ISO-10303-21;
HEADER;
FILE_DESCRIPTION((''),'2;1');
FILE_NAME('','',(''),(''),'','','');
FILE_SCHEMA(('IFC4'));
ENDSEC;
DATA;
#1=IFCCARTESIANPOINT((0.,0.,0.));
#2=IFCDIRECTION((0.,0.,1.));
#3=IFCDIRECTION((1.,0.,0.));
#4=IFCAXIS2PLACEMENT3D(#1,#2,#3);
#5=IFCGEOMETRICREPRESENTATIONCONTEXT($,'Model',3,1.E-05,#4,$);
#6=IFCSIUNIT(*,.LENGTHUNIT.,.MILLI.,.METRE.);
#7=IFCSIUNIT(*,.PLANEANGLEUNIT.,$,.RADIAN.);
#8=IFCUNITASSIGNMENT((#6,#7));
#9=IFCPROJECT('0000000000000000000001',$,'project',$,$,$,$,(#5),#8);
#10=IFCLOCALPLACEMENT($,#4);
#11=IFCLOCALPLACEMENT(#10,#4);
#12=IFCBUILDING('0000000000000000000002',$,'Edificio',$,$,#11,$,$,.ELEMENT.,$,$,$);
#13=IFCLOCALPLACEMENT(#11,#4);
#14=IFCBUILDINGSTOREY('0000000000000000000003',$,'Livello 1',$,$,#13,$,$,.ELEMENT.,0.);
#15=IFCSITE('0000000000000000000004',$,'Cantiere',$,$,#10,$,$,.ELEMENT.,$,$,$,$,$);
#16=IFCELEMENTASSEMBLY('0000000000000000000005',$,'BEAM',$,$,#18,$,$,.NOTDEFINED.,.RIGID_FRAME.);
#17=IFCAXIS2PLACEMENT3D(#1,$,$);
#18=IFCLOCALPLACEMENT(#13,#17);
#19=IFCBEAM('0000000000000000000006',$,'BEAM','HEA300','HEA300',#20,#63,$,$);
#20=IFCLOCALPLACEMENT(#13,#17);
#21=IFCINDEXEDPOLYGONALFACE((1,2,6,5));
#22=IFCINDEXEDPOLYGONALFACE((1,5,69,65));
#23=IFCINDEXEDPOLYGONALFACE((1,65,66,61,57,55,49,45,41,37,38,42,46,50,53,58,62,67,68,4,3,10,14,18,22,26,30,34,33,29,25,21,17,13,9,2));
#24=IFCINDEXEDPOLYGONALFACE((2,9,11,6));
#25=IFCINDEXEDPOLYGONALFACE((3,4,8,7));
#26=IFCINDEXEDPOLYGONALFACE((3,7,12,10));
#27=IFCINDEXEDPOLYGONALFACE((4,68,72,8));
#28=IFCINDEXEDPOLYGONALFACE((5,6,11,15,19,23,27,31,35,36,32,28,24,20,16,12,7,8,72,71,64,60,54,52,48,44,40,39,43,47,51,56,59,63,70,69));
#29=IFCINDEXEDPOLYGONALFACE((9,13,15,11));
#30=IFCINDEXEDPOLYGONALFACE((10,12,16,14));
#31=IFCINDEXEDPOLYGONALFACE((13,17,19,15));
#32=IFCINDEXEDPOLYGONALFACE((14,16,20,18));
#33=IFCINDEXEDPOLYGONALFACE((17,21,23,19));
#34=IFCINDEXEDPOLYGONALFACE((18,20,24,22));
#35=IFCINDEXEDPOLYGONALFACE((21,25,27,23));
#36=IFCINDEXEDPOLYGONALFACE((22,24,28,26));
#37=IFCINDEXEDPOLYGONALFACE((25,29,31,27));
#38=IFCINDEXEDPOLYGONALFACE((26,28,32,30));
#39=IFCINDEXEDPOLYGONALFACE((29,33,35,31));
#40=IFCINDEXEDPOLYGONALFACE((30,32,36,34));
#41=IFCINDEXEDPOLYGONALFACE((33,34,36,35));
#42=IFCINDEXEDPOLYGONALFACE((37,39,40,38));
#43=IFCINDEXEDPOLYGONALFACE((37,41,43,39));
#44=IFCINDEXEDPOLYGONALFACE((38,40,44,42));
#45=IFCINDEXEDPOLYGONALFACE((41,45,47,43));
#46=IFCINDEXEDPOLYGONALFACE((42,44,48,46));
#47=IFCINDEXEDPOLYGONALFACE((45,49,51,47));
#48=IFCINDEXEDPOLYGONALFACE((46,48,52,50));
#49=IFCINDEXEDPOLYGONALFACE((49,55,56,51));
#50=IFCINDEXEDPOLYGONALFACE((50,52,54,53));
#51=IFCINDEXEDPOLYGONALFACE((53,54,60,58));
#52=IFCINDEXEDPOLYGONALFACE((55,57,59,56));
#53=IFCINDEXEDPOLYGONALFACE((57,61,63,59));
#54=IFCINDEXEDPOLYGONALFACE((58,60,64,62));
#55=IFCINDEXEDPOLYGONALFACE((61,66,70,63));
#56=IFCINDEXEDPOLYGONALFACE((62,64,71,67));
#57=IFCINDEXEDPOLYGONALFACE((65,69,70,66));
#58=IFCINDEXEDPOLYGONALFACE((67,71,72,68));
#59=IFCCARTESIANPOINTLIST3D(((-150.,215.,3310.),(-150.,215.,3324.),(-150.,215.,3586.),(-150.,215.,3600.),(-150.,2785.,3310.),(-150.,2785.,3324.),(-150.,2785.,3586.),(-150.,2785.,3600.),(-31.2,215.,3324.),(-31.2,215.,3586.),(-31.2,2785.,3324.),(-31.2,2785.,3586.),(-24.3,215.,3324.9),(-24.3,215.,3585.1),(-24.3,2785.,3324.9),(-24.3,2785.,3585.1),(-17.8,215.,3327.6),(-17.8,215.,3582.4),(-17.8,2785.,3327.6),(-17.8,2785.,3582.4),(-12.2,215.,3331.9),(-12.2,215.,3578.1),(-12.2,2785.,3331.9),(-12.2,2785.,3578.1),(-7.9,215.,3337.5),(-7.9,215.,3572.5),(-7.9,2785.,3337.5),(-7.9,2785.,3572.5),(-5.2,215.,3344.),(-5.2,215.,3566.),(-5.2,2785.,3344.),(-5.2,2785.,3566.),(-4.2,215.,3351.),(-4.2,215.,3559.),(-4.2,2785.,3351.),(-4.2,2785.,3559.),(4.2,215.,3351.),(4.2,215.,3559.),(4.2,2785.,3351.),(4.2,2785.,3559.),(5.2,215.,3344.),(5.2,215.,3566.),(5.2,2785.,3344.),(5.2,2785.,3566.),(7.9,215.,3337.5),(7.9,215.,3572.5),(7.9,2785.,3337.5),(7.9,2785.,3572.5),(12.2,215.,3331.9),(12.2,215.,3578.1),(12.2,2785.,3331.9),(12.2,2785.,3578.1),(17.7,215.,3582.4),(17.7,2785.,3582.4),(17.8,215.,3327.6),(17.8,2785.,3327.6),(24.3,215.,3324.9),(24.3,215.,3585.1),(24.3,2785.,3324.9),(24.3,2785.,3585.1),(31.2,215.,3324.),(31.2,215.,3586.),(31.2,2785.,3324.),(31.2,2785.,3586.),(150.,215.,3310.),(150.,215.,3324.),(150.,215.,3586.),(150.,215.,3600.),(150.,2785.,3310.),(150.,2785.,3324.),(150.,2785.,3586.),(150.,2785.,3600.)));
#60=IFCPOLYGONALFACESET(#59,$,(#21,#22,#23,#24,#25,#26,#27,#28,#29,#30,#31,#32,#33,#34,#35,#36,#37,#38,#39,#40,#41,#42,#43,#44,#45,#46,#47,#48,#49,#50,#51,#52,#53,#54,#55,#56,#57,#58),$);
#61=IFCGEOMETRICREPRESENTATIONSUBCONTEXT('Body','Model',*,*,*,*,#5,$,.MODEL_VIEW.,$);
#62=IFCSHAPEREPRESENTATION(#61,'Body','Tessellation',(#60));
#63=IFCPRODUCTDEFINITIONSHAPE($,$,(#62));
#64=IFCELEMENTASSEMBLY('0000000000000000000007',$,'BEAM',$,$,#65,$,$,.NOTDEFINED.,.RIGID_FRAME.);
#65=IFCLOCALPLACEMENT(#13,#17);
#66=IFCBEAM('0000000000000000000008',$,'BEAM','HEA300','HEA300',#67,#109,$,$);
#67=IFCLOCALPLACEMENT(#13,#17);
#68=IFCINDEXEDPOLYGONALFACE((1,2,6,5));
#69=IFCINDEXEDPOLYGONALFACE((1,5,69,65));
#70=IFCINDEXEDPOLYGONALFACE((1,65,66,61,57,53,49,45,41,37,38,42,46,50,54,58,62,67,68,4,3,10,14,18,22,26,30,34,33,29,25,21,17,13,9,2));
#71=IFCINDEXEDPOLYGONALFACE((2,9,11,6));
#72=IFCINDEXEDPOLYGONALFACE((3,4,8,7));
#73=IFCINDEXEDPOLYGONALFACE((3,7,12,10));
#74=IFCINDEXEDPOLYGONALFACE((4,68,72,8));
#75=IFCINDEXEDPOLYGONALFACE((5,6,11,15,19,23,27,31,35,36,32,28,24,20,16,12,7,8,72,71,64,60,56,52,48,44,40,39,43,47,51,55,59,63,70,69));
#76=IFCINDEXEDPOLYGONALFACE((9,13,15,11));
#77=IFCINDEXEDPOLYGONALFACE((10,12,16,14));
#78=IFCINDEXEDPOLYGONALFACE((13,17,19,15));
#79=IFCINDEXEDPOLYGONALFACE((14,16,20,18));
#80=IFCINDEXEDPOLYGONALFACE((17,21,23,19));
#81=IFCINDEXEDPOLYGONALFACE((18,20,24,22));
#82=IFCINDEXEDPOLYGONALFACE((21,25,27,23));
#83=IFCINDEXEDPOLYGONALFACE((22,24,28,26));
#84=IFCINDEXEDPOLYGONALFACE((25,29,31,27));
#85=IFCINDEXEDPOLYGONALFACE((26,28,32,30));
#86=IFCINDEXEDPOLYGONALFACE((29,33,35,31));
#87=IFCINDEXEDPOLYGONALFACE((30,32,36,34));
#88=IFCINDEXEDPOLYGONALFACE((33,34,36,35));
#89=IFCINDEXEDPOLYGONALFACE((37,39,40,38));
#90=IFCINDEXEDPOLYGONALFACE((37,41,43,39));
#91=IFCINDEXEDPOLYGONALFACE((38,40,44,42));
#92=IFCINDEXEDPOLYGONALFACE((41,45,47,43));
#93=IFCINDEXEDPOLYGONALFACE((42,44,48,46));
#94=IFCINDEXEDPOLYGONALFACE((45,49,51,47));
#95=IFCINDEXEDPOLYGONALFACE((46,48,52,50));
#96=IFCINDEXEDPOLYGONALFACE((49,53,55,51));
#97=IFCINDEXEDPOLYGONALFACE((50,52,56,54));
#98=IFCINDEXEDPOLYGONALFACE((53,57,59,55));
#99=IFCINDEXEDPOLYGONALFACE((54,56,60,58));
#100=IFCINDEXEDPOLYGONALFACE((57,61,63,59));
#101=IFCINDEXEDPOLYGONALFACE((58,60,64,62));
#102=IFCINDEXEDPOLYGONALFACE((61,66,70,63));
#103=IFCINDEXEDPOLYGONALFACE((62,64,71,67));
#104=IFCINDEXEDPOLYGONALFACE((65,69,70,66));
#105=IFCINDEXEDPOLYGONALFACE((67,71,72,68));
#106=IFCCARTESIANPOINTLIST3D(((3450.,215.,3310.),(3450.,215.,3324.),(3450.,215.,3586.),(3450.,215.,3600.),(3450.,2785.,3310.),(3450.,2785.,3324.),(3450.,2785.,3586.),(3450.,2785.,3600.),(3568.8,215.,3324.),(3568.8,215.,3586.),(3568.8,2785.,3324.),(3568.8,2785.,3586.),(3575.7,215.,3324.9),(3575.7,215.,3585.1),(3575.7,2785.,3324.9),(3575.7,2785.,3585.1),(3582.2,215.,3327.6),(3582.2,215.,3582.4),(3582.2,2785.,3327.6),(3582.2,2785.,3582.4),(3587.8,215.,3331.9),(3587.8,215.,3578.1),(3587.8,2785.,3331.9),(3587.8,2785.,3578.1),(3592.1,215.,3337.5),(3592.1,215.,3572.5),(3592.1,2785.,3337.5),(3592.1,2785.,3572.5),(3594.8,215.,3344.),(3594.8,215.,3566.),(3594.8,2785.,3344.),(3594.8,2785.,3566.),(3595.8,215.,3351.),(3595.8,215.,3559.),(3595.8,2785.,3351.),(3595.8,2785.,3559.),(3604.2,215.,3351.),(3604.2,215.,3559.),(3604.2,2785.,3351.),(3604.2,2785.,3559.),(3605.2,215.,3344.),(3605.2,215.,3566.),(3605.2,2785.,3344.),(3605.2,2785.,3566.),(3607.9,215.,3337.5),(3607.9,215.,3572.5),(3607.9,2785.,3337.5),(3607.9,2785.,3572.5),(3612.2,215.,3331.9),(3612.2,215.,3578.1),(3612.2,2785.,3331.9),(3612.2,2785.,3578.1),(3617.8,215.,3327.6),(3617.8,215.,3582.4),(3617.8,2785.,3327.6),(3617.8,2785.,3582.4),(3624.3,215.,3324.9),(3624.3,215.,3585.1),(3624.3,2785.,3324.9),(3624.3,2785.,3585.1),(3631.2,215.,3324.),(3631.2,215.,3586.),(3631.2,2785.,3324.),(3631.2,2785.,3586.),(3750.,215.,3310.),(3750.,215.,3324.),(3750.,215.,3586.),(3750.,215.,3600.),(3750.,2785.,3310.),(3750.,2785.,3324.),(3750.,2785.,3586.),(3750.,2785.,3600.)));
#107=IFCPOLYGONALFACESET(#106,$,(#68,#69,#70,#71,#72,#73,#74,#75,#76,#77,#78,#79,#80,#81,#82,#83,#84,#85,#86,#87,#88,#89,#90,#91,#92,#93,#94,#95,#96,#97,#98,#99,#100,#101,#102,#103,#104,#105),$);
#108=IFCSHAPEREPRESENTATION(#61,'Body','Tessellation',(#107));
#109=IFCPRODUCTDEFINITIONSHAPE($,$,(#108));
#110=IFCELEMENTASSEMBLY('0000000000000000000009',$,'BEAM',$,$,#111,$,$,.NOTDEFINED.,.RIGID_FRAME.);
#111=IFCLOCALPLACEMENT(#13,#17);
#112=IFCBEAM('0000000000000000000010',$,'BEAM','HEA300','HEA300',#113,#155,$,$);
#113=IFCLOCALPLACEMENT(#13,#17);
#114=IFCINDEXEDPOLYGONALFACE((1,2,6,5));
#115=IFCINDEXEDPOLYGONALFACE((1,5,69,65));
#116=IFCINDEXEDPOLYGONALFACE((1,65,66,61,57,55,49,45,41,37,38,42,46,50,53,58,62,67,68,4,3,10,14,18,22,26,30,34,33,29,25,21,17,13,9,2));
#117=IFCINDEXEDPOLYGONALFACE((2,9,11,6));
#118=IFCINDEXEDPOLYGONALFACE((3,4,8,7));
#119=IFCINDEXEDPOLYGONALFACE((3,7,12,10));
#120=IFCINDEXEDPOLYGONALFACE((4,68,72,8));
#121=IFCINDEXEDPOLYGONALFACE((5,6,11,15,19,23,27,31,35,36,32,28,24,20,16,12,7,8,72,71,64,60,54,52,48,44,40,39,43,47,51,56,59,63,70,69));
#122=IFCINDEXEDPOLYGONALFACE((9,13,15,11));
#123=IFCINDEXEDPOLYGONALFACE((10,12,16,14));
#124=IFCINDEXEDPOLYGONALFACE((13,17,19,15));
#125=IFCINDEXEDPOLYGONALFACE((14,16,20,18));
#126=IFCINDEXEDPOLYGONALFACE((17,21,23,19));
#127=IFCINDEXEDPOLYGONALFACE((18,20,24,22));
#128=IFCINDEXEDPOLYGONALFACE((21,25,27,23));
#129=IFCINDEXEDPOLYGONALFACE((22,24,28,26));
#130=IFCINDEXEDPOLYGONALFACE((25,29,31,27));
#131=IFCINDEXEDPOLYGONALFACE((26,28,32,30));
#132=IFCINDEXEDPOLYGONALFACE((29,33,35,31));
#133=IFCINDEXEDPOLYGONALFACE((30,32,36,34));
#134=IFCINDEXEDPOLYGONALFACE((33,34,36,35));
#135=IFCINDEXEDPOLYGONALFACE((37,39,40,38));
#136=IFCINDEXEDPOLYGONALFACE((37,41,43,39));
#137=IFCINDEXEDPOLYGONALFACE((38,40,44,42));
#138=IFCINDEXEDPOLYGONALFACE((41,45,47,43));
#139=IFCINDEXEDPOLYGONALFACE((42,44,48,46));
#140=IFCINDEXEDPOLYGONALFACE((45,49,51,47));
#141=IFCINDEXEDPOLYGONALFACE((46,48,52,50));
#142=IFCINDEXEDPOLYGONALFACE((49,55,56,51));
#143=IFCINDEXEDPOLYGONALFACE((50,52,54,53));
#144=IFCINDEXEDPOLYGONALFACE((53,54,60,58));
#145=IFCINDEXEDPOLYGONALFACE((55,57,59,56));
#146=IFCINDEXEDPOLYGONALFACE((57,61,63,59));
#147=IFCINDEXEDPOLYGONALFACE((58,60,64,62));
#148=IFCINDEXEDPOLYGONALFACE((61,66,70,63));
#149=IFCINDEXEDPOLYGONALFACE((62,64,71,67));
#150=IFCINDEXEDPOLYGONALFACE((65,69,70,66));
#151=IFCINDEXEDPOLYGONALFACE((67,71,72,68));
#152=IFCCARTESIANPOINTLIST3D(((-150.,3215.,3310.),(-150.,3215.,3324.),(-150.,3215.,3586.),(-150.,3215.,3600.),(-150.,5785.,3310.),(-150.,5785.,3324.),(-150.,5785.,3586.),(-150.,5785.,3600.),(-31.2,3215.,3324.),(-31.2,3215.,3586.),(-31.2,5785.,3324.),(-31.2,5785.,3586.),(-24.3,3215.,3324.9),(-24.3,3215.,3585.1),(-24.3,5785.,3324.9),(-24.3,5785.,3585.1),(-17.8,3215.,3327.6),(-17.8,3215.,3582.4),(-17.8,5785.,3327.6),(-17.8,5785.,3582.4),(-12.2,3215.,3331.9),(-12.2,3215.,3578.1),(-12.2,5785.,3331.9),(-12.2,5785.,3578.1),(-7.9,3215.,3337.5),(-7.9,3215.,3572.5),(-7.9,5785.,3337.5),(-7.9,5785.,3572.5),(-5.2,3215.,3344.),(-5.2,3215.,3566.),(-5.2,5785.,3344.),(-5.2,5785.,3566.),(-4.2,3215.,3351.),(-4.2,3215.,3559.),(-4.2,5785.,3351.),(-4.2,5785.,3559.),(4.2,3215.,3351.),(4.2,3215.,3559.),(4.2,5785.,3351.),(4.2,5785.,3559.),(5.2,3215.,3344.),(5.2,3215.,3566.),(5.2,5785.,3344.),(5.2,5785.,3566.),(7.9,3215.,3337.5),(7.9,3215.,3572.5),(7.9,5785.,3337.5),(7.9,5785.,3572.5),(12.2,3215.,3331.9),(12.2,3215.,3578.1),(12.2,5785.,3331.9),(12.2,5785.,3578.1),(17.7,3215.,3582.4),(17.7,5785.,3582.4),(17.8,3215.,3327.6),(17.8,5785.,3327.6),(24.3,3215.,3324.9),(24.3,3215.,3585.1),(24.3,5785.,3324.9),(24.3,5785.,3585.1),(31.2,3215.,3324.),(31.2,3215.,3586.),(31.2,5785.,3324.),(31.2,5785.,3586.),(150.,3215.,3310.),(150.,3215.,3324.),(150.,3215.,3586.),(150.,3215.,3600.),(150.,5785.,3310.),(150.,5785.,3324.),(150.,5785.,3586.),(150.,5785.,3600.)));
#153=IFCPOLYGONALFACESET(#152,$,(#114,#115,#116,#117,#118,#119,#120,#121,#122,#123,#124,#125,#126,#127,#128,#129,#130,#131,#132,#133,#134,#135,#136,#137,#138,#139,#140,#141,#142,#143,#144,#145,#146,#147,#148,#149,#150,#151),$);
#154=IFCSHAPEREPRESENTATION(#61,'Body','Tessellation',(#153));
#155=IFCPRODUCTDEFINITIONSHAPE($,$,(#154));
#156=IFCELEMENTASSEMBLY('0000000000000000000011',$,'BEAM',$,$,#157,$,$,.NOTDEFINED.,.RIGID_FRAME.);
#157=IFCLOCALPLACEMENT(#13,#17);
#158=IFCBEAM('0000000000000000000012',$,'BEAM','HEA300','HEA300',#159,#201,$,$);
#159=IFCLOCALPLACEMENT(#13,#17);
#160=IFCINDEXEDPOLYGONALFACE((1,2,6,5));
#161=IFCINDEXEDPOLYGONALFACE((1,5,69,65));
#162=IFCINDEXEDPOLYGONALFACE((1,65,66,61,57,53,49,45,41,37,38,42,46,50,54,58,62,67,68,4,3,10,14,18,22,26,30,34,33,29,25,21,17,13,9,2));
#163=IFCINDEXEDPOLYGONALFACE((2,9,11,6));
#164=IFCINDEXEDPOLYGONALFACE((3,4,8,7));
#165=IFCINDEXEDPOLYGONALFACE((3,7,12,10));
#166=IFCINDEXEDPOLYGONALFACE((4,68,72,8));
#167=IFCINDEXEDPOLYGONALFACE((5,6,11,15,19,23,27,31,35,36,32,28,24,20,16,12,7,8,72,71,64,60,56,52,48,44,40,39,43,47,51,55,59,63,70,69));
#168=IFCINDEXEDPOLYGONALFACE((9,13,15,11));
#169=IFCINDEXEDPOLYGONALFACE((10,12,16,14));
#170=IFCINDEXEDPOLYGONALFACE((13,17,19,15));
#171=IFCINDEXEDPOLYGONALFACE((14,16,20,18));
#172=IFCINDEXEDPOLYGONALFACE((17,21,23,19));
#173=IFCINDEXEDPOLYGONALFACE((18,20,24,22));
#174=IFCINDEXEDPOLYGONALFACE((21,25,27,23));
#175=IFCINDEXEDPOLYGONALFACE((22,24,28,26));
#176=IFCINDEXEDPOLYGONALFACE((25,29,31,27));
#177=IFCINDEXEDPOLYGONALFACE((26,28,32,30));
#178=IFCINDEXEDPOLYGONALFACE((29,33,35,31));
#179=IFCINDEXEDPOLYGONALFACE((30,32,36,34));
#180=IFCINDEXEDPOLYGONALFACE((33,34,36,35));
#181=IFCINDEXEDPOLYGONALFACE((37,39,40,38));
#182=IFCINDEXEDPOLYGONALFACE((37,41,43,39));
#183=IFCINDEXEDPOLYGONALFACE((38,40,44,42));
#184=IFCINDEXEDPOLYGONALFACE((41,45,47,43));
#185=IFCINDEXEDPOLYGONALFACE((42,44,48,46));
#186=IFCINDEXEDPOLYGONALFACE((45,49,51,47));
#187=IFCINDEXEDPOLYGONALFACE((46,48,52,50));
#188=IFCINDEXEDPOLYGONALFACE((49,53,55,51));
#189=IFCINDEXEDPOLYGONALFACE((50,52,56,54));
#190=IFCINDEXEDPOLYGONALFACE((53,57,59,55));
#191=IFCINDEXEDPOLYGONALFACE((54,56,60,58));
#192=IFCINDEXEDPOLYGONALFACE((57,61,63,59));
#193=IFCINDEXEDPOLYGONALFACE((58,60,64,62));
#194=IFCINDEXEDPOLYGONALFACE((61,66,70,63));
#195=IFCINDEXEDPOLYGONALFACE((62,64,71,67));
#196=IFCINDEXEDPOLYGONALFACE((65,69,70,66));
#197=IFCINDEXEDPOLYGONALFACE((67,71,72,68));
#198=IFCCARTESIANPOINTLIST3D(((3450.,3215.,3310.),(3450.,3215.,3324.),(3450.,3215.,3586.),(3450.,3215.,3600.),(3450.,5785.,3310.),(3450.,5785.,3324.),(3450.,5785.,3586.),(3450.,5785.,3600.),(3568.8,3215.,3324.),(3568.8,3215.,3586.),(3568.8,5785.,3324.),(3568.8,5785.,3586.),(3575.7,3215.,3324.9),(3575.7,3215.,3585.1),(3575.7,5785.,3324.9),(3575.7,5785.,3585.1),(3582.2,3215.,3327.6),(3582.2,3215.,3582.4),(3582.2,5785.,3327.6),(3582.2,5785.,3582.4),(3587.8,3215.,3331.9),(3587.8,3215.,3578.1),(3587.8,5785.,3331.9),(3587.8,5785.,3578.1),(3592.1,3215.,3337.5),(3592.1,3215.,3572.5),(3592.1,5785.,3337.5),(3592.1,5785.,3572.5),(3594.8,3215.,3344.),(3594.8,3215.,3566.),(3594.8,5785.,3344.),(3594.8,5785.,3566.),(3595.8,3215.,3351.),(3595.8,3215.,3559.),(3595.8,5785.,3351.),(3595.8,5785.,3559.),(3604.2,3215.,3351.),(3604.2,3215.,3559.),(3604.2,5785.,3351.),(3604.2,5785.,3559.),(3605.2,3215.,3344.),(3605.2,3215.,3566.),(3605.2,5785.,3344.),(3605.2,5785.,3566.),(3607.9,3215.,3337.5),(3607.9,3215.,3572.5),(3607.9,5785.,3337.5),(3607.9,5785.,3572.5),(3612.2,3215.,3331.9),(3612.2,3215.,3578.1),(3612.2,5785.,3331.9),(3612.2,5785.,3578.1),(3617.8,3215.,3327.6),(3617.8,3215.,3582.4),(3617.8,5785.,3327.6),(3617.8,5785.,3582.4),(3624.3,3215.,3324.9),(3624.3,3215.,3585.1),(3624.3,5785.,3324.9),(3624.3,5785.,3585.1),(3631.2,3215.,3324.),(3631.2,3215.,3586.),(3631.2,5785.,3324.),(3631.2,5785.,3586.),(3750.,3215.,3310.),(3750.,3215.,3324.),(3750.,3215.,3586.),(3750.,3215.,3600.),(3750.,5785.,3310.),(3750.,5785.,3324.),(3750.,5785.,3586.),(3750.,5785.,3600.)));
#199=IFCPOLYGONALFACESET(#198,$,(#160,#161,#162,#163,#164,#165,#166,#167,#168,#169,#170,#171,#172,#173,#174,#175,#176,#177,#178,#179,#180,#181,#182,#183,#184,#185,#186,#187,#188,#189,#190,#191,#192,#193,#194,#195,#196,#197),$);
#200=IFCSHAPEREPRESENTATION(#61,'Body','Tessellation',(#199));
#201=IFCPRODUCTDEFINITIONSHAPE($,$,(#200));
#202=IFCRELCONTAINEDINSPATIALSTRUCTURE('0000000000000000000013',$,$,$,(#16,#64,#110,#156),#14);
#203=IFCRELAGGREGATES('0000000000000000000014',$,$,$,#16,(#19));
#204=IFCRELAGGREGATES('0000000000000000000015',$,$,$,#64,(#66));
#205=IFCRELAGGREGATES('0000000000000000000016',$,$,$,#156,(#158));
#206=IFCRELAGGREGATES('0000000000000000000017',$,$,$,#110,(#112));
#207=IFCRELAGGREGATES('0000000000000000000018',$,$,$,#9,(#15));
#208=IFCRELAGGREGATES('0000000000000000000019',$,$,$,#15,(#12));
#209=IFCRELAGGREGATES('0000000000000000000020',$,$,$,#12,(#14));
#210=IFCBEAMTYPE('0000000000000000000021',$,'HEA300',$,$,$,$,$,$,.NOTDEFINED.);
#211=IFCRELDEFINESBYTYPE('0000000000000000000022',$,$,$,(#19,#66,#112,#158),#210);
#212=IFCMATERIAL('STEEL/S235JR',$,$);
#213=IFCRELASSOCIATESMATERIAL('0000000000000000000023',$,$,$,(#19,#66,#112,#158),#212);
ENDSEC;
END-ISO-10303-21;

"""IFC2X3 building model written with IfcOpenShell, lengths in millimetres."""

from ifc_helpers import new_model, si_unit, frame, origin_with_axes, origin_2d_with_axis, place, context, subcontext, project, spatial, i_section, extrude, clip, halfspace, material, type_object, element, aggregate, save


model = new_model("IFC2X3")

# Units and contexts
model_context = context("Model", 3, precision=1e-05, world=origin_with_axes())
body_context = subcontext(model_context, "Body", "Model", "MODEL_VIEW")
ifc_project = project(units=[si_unit("LENGTHUNIT", "METRE", prefix="MILLI"), si_unit("PLANEANGLEUNIT", "RADIAN")], contexts=[model_context])

# Site, building, storey
site_placement = place(None, origin_with_axes())
site = spatial("IfcSite", under=ifc_project, at=site_placement, Name="Cantiere", CompositionType="ELEMENT")
building_placement = place(site_placement, origin_with_axes())
building = spatial("IfcBuilding", under=site, at=building_placement, Name="Edificio", CompositionType="ELEMENT")
storey_placement = place(building_placement, origin_with_axes())
storey = spatial("IfcBuildingStorey", under=building, at=storey_placement, Name="Livello 1", CompositionType="ELEMENT", Elevation=0.0)

# Element assemblies, beams
assembly_1_placement = place(storey_placement, origin_with_axes())
assembly_1 = element("IfcElementAssembly", 1, at=assembly_1_placement, inside=storey, Name="BEAM", AssemblyPlace="NOTDEFINED", PredefinedType="RIGID_FRAME")
ifc_material_1 = material(Name="STEEL/S235JR")
beam_type = type_object("IfcBeamType", Name="HEA300", PredefinedType="NOTDEFINED")
beam_1_placement = place(assembly_1_placement, frame((0.0, 3000.0, 3455.0), z_axis=(0.0, 0.0, 1.0), x_axis=(0.0, -1.0, 0.0)))
beam_1 = element("IfcBeam", 2, at=beam_1_placement, type_object=beam_type, material=ifc_material_1, Name="BEAM", Description="HEA300", ObjectType="HEA300", context=body_context, shape_type="Clipping", body=[
    clip(clip(extrude(i_section(OverallWidth=300.0, OverallDepth=290.0, WebThickness=8.5, FlangeThickness=14.0, FilletRadius=27.0, at=origin_2d_with_axis()), frame((2785.0, 0.0, 0.0), z_axis=(-1.0, 0.0, 0.0), x_axis=(0.0, -1.0, 0.0)), (0.0, 0.0, 1.0), 2570.0), halfspace(frame((2785.0, 0.0, -145.0), z_axis=(-1.0, 0.0, 0.0), x_axis=(0.0, 1.0, 0.0)), True)), halfspace(frame((215.0, 0.0, -145.0), z_axis=(1.0, 0.0, 0.0), x_axis=(0.0, -1.0, 0.0)), True)),
])
aggregate(assembly_1, [beam_1])
assembly_2_placement = place(storey_placement, origin_with_axes())
assembly_2 = element("IfcElementAssembly", 3, at=assembly_2_placement, inside=storey, Name="BEAM", AssemblyPlace="NOTDEFINED", PredefinedType="RIGID_FRAME")
beam_2_placement = place(assembly_2_placement, frame((3600.0, 3000.0, 3455.0), z_axis=(0.0, 0.0, 1.0), x_axis=(0.0, -1.0, 0.0)))
beam_2 = element("IfcBeam", 4, at=beam_2_placement, type_object=beam_type, material=ifc_material_1, Name="BEAM", Description="HEA300", ObjectType="HEA300", context=body_context, shape_type="Clipping", body=[
    clip(clip(extrude(i_section(OverallWidth=300.0, OverallDepth=290.0, WebThickness=8.5, FlangeThickness=14.0, FilletRadius=27.0, at=origin_2d_with_axis()), frame((2785.0, 0.0, 0.0), z_axis=(-1.0, 0.0, 0.0), x_axis=(0.0, -1.0, 0.0)), (0.0, 0.0, 1.0), 2570.0), halfspace(frame((2785.0, 0.0, -145.0), z_axis=(-1.0, 0.0, 0.0), x_axis=(0.0, 1.0, 0.0)), True)), halfspace(frame((215.0, 0.0, -145.0), z_axis=(1.0, 0.0, 0.0), x_axis=(0.0, -1.0, 0.0)), True)),
])
aggregate(assembly_2, [beam_2])
assembly_3_placement = place(storey_placement, origin_with_axes())
assembly_3 = element("IfcElementAssembly", 5, at=assembly_3_placement, inside=storey, Name="BEAM", AssemblyPlace="NOTDEFINED", PredefinedType="RIGID_FRAME")
beam_3_placement = place(assembly_3_placement, frame((0.0, 6000.0, 3455.0), z_axis=(0.0, 0.0, 1.0), x_axis=(0.0, -1.0, 0.0)))
beam_3 = element("IfcBeam", 6, at=beam_3_placement, type_object=beam_type, material=ifc_material_1, Name="BEAM", Description="HEA300", ObjectType="HEA300", context=body_context, shape_type="Clipping", body=[
    clip(clip(extrude(i_section(OverallWidth=300.0, OverallDepth=290.0, WebThickness=8.5, FlangeThickness=14.0, FilletRadius=27.0, at=origin_2d_with_axis()), frame((2785.0, 0.0, 0.0), z_axis=(-1.0, 0.0, 0.0), x_axis=(0.0, -1.0, 0.0)), (0.0, 0.0, 1.0), 2570.0), halfspace(frame((2785.0, 0.0, -145.0), z_axis=(-1.0, 0.0, 0.0), x_axis=(0.0, 1.0, 0.0)), True)), halfspace(frame((215.0, 0.0, -145.0), z_axis=(1.0, 0.0, 0.0), x_axis=(0.0, -1.0, 0.0)), True)),
])
assembly_4_placement = place(storey_placement, origin_with_axes())
assembly_4 = element("IfcElementAssembly", 7, at=assembly_4_placement, inside=storey, Name="BEAM", AssemblyPlace="NOTDEFINED", PredefinedType="RIGID_FRAME")
beam_4_placement = place(assembly_4_placement, frame((3600.0, 6000.0, 3455.0), z_axis=(0.0, 0.0, 1.0), x_axis=(0.0, -1.0, 0.0)))
beam_4 = element("IfcBeam", 8, at=beam_4_placement, type_object=beam_type, material=ifc_material_1, Name="BEAM", Description="HEA300", ObjectType="HEA300", context=body_context, shape_type="Clipping", body=[
    clip(clip(extrude(i_section(OverallWidth=300.0, OverallDepth=290.0, WebThickness=8.5, FlangeThickness=14.0, FilletRadius=27.0, at=origin_2d_with_axis()), frame((2785.0, 0.0, 0.0), z_axis=(-1.0, 0.0, 0.0), x_axis=(0.0, -1.0, 0.0)), (0.0, 0.0, 1.0), 2570.0), halfspace(frame((2785.0, 0.0, -145.0), z_axis=(-1.0, 0.0, 0.0), x_axis=(0.0, 1.0, 0.0)), True)), halfspace(frame((215.0, 0.0, -145.0), z_axis=(1.0, 0.0, 0.0), x_axis=(0.0, -1.0, 0.0)), True)),
])

aggregate(assembly_4, [beam_4])
aggregate(assembly_3, [beam_3])

save(model, "model.ifc")
